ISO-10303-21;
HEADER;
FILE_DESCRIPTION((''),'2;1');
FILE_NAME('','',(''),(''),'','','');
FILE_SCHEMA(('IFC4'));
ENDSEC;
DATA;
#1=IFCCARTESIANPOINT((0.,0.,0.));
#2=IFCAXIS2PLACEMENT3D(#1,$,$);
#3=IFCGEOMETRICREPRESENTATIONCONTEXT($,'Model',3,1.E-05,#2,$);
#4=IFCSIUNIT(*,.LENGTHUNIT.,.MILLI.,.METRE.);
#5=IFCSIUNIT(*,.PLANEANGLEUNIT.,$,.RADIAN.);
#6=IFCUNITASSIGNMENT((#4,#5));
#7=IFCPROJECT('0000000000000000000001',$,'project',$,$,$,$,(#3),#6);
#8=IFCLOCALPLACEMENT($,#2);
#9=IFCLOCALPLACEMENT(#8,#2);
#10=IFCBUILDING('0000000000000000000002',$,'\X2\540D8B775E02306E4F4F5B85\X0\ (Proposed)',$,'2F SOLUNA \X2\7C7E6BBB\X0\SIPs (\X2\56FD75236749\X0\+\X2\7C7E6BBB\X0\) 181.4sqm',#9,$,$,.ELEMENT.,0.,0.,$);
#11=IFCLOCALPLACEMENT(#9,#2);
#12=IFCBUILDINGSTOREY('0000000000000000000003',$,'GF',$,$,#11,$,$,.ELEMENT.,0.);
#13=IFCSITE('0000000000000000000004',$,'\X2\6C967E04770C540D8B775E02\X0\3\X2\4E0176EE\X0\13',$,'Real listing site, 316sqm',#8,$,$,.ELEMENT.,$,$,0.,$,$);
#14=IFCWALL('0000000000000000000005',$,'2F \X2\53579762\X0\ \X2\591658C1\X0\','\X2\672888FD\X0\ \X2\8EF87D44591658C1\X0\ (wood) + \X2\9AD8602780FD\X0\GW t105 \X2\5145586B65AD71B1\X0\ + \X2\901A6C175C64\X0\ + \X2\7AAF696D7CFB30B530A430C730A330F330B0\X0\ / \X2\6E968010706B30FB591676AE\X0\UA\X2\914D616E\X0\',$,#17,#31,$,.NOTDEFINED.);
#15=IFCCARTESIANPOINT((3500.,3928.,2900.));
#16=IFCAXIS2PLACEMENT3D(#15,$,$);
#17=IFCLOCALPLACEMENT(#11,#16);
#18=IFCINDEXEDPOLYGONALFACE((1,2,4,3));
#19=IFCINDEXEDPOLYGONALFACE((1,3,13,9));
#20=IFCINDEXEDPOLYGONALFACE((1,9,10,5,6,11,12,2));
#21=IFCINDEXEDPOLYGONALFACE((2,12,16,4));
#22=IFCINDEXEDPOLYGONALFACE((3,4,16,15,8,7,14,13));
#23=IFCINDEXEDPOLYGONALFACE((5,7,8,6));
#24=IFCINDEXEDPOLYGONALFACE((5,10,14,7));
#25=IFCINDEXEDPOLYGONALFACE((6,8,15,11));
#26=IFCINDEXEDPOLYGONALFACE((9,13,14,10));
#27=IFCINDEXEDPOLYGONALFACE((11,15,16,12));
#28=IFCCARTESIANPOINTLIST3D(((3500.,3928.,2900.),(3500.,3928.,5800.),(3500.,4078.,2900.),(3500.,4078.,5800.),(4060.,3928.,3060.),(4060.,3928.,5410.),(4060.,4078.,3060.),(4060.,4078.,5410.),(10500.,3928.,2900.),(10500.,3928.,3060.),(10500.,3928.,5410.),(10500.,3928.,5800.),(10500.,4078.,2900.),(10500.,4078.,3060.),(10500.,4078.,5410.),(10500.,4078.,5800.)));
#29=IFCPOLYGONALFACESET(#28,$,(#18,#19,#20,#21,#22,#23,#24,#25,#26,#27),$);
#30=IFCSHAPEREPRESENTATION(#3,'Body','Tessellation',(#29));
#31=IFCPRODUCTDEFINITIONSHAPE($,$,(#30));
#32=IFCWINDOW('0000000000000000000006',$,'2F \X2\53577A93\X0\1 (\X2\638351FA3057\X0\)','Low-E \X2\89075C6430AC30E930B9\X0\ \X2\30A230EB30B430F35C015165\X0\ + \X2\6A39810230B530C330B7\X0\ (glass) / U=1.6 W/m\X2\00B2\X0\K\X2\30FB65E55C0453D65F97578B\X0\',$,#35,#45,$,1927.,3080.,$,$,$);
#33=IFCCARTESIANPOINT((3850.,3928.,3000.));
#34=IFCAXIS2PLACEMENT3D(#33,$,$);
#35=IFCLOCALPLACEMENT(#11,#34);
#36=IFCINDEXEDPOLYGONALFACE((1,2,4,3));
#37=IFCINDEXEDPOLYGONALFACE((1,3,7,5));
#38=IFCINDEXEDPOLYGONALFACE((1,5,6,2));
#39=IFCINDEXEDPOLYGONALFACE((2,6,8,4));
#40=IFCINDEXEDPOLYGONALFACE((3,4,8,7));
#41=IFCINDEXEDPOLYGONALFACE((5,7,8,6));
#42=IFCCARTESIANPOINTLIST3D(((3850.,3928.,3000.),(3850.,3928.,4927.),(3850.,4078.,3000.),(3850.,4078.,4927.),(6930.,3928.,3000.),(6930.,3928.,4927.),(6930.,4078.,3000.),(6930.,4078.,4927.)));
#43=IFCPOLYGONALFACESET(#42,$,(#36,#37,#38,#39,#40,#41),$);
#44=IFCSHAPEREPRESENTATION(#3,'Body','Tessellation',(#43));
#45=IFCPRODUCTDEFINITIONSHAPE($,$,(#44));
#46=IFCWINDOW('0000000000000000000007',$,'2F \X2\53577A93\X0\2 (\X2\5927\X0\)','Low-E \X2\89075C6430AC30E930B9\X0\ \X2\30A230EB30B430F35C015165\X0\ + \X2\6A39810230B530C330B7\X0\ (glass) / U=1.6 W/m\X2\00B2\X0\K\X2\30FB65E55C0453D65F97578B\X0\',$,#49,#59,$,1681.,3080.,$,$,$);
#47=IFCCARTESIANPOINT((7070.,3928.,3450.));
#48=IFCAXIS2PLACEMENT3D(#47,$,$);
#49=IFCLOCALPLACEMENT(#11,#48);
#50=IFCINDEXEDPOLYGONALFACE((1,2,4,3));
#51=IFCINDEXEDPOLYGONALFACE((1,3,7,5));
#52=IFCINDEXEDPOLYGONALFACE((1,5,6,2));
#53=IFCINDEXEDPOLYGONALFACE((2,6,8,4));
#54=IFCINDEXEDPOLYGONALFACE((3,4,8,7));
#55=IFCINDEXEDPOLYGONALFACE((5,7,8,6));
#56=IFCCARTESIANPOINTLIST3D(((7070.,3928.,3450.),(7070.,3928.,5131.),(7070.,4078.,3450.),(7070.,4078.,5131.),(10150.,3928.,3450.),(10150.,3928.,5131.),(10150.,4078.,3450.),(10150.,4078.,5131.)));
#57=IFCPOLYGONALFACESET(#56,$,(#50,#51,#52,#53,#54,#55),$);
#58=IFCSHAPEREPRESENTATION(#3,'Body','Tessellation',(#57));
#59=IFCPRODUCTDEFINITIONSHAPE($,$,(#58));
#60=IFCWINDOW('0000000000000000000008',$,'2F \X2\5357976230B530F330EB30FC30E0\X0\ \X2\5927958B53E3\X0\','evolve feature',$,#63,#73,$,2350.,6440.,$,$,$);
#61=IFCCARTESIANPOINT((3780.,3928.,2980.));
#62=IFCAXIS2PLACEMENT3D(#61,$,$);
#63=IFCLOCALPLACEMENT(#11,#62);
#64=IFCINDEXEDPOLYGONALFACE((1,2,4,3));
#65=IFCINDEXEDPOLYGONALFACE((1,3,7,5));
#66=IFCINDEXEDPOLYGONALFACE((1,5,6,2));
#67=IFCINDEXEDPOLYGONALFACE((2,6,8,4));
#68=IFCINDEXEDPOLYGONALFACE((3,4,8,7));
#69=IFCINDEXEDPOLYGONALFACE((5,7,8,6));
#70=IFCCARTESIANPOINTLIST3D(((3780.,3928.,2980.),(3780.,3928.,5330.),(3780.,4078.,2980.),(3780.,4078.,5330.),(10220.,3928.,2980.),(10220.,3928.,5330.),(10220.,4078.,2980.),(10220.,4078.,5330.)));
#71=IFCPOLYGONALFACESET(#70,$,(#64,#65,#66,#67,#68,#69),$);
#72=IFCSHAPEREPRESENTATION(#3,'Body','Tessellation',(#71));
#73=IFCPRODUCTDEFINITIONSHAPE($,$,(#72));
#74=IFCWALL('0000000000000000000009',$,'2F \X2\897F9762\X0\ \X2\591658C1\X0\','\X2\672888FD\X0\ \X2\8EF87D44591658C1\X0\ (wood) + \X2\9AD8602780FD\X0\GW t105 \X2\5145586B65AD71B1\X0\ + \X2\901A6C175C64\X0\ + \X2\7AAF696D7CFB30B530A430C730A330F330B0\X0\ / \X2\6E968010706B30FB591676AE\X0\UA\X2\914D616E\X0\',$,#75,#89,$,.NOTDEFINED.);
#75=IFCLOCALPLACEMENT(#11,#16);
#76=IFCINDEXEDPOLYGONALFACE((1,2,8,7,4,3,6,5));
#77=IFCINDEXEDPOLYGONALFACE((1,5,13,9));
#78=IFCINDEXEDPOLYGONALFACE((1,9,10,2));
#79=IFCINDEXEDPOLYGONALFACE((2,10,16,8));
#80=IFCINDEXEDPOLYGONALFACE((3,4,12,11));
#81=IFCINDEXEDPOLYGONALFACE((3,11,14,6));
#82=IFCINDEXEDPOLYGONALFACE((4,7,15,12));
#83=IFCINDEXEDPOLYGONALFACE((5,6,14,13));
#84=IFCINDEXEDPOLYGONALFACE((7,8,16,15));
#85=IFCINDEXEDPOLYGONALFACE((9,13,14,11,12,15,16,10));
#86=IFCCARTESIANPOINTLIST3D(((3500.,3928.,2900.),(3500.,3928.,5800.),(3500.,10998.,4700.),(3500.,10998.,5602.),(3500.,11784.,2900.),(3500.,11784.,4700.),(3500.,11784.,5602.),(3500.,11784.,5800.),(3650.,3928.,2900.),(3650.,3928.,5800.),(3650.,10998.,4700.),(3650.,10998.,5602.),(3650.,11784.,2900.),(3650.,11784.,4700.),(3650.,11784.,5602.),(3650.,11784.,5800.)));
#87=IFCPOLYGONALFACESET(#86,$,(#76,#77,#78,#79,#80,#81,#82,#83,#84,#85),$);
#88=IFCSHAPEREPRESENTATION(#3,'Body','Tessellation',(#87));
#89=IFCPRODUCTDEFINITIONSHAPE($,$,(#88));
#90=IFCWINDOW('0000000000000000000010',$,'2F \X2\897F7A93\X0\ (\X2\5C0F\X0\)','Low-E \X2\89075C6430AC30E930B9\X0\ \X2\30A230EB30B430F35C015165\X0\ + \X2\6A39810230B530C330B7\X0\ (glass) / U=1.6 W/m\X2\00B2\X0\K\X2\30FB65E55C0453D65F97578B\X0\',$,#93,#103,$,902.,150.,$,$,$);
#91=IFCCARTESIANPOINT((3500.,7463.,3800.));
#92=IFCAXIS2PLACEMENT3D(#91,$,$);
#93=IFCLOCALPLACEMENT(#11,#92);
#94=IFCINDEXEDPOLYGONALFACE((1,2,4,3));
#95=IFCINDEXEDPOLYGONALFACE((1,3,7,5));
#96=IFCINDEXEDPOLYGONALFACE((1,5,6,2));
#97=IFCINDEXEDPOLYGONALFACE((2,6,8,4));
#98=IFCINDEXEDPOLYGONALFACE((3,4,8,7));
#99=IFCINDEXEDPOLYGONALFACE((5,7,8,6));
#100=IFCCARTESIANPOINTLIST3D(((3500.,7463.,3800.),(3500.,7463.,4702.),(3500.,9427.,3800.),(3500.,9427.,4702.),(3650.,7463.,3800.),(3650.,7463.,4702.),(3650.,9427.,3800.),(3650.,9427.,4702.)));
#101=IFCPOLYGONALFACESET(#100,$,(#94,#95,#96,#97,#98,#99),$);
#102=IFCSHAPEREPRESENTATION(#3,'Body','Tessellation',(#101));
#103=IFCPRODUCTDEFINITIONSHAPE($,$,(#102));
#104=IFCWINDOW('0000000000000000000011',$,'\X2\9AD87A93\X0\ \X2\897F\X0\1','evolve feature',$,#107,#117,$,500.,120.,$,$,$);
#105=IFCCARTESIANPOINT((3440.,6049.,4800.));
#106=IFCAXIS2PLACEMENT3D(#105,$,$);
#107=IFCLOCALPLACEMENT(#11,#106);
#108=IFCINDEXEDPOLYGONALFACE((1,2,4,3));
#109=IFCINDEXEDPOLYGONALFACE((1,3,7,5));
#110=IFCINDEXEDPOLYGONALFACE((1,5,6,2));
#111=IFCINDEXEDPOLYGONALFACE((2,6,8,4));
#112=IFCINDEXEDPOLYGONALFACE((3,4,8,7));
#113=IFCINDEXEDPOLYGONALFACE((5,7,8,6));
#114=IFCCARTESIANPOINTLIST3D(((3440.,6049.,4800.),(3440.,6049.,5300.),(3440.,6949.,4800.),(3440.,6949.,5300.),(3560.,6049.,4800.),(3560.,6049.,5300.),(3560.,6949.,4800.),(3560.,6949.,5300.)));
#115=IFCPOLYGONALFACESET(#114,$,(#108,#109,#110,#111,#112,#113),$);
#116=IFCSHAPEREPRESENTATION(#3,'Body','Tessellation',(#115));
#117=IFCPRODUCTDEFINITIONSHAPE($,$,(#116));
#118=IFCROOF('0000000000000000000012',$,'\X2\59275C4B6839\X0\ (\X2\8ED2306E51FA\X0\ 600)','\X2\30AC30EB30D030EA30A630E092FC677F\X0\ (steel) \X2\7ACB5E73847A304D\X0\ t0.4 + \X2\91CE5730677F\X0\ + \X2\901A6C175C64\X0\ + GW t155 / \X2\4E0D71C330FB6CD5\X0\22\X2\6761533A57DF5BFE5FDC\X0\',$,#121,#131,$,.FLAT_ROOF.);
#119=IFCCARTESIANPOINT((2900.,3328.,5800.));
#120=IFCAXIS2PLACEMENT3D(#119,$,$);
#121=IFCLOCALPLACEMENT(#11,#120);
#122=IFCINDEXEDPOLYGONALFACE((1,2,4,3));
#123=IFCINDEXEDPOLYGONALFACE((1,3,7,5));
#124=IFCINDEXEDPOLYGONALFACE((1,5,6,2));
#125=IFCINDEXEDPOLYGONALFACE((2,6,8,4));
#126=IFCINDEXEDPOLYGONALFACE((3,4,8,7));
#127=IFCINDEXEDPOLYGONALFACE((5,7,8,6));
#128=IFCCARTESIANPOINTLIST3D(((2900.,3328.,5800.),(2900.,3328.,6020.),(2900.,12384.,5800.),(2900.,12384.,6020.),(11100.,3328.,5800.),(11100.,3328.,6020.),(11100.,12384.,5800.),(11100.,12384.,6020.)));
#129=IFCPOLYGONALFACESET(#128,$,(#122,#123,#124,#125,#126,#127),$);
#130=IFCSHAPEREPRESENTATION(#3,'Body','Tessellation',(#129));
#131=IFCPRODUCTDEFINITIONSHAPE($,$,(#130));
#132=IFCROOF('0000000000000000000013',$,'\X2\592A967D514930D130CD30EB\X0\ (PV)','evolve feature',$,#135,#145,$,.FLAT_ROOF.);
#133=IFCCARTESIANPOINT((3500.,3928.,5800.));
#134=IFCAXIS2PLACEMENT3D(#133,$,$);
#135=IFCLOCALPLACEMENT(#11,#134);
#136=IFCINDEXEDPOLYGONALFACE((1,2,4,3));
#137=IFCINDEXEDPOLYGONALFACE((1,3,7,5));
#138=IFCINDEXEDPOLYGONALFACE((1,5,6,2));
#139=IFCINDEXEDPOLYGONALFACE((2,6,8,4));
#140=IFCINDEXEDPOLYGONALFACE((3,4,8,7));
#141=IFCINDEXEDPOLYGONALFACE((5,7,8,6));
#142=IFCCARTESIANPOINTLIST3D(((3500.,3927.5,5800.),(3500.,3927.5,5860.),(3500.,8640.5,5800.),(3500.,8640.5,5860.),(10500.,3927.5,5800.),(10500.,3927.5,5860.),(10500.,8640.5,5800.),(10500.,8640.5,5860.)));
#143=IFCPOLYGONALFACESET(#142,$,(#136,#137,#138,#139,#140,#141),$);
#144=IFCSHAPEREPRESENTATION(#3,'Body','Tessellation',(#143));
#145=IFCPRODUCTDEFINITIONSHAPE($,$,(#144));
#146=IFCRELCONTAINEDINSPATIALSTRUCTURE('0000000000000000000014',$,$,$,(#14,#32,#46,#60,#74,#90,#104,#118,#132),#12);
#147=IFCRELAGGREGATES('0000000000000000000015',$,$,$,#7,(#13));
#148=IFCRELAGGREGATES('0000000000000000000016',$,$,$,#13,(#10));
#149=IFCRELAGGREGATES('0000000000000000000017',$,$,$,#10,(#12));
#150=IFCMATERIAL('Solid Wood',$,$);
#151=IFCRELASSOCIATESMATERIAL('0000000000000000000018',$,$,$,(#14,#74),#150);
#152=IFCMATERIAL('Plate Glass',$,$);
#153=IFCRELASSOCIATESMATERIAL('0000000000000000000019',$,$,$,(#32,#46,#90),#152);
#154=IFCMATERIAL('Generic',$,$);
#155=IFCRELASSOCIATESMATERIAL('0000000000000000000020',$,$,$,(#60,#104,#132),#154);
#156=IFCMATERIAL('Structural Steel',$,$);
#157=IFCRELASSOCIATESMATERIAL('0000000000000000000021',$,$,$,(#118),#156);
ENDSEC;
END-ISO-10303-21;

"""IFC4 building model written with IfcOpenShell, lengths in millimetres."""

from ifc_helpers import new_model, si_unit, frame, frame_2d, origin, place, context, project, spatial, rectangle, extrude, material, element, fill, save


model = new_model("IFC4")

# Units and contexts
model_context = context("Model", 3, precision=1e-05, world=origin())
ifc_project = project(units=[si_unit("LENGTHUNIT", "METRE", prefix="MILLI"), si_unit("PLANEANGLEUNIT", "RADIAN")], contexts=[model_context])

# Site, building, storey
site_placement = place(None, origin())
site = spatial("IfcSite", under=ifc_project, at=site_placement, Name="沖縄県名護市3丁目13", ObjectType="Real listing site, 316sqm", CompositionType="ELEMENT", RefElevation=0.0)
building_placement = place(site_placement, origin())
building = spatial("IfcBuilding", under=site, at=building_placement, Name="名護市の住宅 (Proposed)", ObjectType="2F SOLUNA 籾殻SIPs (国産杉+籾殻) 181.4sqm", CompositionType="ELEMENT", ElevationOfRefHeight=0.0, ElevationOfTerrain=0.0)
storey_placement = place(building_placement, origin())
storey = spatial("IfcBuildingStorey", under=building, at=storey_placement, Name="GF", CompositionType="ELEMENT", Elevation=0.0)

# Shared definitions
ifc_material_1 = material(Name="Solid Wood")
ifc_material_2 = material(Name="Generic")

# Shared definitions
ifc_material_3 = material(Name="Plate Glass")

# Walls, openings, windows
wall_1_placement = place(storey_placement, frame((3500.0, 3928.0, 2900.0)))
wall_1 = element("IfcWall", 1, at=wall_1_placement, inside=storey, material=ifc_material_1, Name="2F 南面 外壁", Description="木製 軸組外壁 (wood) + 高性能GW t105 充填断熱 + 通気層 + 窯業系サイディング / 準耐火・外皮UA配慮", PredefinedType="NOTDEFINED", context=model_context, shape_type="SweptSolid", body=[
    extrude(rectangle(XDim=7000.0, YDim=150.0, at=frame_2d((3500.0, 75.0))), frame((3500.0, 3928.0, 2900.0)), (0.0, 0.0, 1.0), 2900.0),
])
opening_1_placement = place(storey_placement, frame((3850.0, 3928.0, 3000.0)))
opening_1 = element("IfcOpeningElement", 2, at=opening_1_placement, cuts=wall_1, PredefinedType="NOTDEFINED", context=model_context, shape_type="SweptSolid", body=[
    extrude(rectangle(XDim=3080.0, YDim=150.0, at=frame_2d((1540.0, 75.0))), frame((3850.0, 3928.0, 3000.0)), (0.0, 0.0, 1.0), 1927.0),
])
opening_2_placement = place(storey_placement, frame((7070.0, 3928.0, 3450.0)))
opening_2 = element("IfcOpeningElement", 3, at=opening_2_placement, cuts=wall_1, PredefinedType="NOTDEFINED", context=model_context, shape_type="SweptSolid", body=[
    extrude(rectangle(XDim=3080.0, YDim=150.0, at=frame_2d((1540.0, 75.0))), frame((7070.0, 3928.0, 3450.0)), (0.0, 0.0, 1.0), 1681.0),
])
opening_3_placement = place(storey_placement, frame((3780.0, 3928.0, 2980.0)))
opening_3 = element("IfcOpeningElement", 4, at=opening_3_placement, cuts=wall_1, PredefinedType="NOTDEFINED", context=model_context, shape_type="SweptSolid", body=[
    extrude(rectangle(XDim=6440.0, YDim=150.0, at=frame_2d((3220.0, 75.0))), frame((3780.0, 3928.0, 2980.0)), (0.0, 0.0, 1.0), 2350.0),
])
window_1_placement = place(storey_placement, frame((3850.0, 3928.0, 3000.0)))
window_1 = element("IfcWindow", 5, at=window_1_placement, inside=storey, material=ifc_material_3, Name="2F 南窓1 (掃出し)", Description="Low-E 複層ガラス アルゴン封入 + 樹脂サッシ (glass) / U=1.6 W/m²K・日射取得型", OverallHeight=1927.0, OverallWidth=3080.0, context=model_context, shape_type="SweptSolid", body=[
    extrude(rectangle(XDim=3080.0, YDim=150.0, at=frame_2d((1540.0, 75.0))), frame((3850.0, 3928.0, 3000.0)), (0.0, 0.0, 1.0), 1927.0),
])
fill(opening_1, window_1)
window_2_placement = place(storey_placement, frame((7070.0, 3928.0, 3450.0)))
window_2 = element("IfcWindow", 6, at=window_2_placement, inside=storey, material=ifc_material_3, Name="2F 南窓2 (大)", Description="Low-E 複層ガラス アルゴン封入 + 樹脂サッシ (glass) / U=1.6 W/m²K・日射取得型", OverallHeight=1681.0, OverallWidth=3080.0, context=model_context, shape_type="SweptSolid", body=[
    extrude(rectangle(XDim=3080.0, YDim=150.0, at=frame_2d((1540.0, 75.0))), frame((7070.0, 3928.0, 3450.0)), (0.0, 0.0, 1.0), 1681.0),
])
fill(opening_2, window_2)
window_3_placement = place(storey_placement, frame((3780.0, 3928.0, 2980.0)))
window_3 = element("IfcWindow", 7, at=window_3_placement, inside=storey, material=ifc_material_2, Name="2F 南面サンルーム 大開口", Description="evolve feature", OverallHeight=2350.0, OverallWidth=6440.0, context=model_context, shape_type="SweptSolid", body=[
    extrude(rectangle(XDim=6440.0, YDim=150.0, at=frame_2d((3220.0, 75.0))), frame((3780.0, 3928.0, 2980.0)), (0.0, 0.0, 1.0), 2350.0),
])
fill(opening_3, window_3)
wall_2_placement = place(storey_placement, frame((3500.0, 3928.0, 2900.0)))
wall_2 = element("IfcWall", 8, at=wall_2_placement, inside=storey, material=ifc_material_1, Name="2F 西面 外壁", Description="木製 軸組外壁 (wood) + 高性能GW t105 充填断熱 + 通気層 + 窯業系サイディング / 準耐火・外皮UA配慮", PredefinedType="NOTDEFINED", context=model_context, shape_type="SweptSolid", body=[
    extrude(rectangle(XDim=150.0, YDim=7856.0, at=frame_2d((75.0, 3928.0))), frame((3500.0, 3928.0, 2900.0)), (0.0, 0.0, 1.0), 2900.0),
])
opening_4_placement = place(storey_placement, frame((3500.0, 7463.0, 3800.0)))
opening_4 = element("IfcOpeningElement", 9, at=opening_4_placement, cuts=wall_2, PredefinedType="NOTDEFINED", context=model_context, shape_type="SweptSolid", body=[
    extrude(rectangle(XDim=150.0, YDim=1964.0, at=frame_2d((75.0, 982.0))), frame((3500.0, 7463.0, 3800.0)), (0.0, 0.0, 1.0), 902.0),
])
opening_5_placement = place(storey_placement, frame((3440.0, 6049.0, 4800.0)))
opening_5 = element("IfcOpeningElement", 10, at=opening_5_placement, cuts=wall_2, PredefinedType="NOTDEFINED", context=model_context, shape_type="SweptSolid", body=[
    extrude(rectangle(XDim=120.0, YDim=900.0, at=frame_2d((60.0, 450.0))), frame((3440.0, 6049.0, 4800.0)), (0.0, 0.0, 1.0), 500.0),
])
window_4_placement = place(storey_placement, frame((3500.0, 7463.0, 3800.0)))
window_4 = element("IfcWindow", 11, at=window_4_placement, inside=storey, material=ifc_material_3, Name="2F 西窓 (小)", Description="Low-E 複層ガラス アルゴン封入 + 樹脂サッシ (glass) / U=1.6 W/m²K・日射取得型", OverallHeight=902.0, OverallWidth=150.0, context=model_context, shape_type="SweptSolid", body=[
    extrude(rectangle(XDim=150.0, YDim=1964.0, at=frame_2d((75.0, 982.0))), frame((3500.0, 7463.0, 3800.0)), (0.0, 0.0, 1.0), 902.0),
])
fill(opening_4, window_4)
window_5_placement = place(storey_placement, frame((3440.0, 6049.0, 4800.0)))
window_5 = element("IfcWindow", 12, at=window_5_placement, inside=storey, material=ifc_material_2, Name="高窓 西1", Description="evolve feature", OverallHeight=500.0, OverallWidth=120.0, context=model_context, shape_type="SweptSolid", body=[
    extrude(rectangle(XDim=120.0, YDim=900.0, at=frame_2d((60.0, 450.0))), frame((3440.0, 6049.0, 4800.0)), (0.0, 0.0, 1.0), 500.0),
])
fill(opening_5, window_5)

# Roofs
ifc_material_4 = material(Name="Structural Steel")
roof_1_placement = place(storey_placement, frame((2900.0, 3328.0, 5800.0)))
element("IfcRoof", 13, at=roof_1_placement, inside=storey, material=ifc_material_4, Name="大屋根 (軒の出 600)", Description="ガルバリウム鋼板 (steel) 立平葺き t0.4 + 野地板 + 通気層 + GW t155 / 不燃・法22条区域対応", PredefinedType="FLAT_ROOF", context=model_context, shape_type="SweptSolid", body=[
    extrude(rectangle(XDim=8200.0, YDim=9056.0, at=frame_2d((4100.0, 4528.0))), frame((2900.0, 3328.0, 5800.0)), (0.0, 0.0, 1.0), 220.0),
])
roof_2_placement = place(storey_placement, frame((3500.0, 3928.0, 5800.0)))
element("IfcRoof", 14, at=roof_2_placement, inside=storey, material=ifc_material_2, Name="太陽光パネル (PV)", Description="evolve feature", PredefinedType="FLAT_ROOF", context=model_context, shape_type="SweptSolid", body=[
    extrude(rectangle(XDim=7000.0, YDim=4713.0, at=frame_2d((3500.0, 2356.0))), frame((3500.0, 3928.0, 5800.0)), (0.0, 0.0, 1.0), 60.0),
])

save(model, "model.ifc")
